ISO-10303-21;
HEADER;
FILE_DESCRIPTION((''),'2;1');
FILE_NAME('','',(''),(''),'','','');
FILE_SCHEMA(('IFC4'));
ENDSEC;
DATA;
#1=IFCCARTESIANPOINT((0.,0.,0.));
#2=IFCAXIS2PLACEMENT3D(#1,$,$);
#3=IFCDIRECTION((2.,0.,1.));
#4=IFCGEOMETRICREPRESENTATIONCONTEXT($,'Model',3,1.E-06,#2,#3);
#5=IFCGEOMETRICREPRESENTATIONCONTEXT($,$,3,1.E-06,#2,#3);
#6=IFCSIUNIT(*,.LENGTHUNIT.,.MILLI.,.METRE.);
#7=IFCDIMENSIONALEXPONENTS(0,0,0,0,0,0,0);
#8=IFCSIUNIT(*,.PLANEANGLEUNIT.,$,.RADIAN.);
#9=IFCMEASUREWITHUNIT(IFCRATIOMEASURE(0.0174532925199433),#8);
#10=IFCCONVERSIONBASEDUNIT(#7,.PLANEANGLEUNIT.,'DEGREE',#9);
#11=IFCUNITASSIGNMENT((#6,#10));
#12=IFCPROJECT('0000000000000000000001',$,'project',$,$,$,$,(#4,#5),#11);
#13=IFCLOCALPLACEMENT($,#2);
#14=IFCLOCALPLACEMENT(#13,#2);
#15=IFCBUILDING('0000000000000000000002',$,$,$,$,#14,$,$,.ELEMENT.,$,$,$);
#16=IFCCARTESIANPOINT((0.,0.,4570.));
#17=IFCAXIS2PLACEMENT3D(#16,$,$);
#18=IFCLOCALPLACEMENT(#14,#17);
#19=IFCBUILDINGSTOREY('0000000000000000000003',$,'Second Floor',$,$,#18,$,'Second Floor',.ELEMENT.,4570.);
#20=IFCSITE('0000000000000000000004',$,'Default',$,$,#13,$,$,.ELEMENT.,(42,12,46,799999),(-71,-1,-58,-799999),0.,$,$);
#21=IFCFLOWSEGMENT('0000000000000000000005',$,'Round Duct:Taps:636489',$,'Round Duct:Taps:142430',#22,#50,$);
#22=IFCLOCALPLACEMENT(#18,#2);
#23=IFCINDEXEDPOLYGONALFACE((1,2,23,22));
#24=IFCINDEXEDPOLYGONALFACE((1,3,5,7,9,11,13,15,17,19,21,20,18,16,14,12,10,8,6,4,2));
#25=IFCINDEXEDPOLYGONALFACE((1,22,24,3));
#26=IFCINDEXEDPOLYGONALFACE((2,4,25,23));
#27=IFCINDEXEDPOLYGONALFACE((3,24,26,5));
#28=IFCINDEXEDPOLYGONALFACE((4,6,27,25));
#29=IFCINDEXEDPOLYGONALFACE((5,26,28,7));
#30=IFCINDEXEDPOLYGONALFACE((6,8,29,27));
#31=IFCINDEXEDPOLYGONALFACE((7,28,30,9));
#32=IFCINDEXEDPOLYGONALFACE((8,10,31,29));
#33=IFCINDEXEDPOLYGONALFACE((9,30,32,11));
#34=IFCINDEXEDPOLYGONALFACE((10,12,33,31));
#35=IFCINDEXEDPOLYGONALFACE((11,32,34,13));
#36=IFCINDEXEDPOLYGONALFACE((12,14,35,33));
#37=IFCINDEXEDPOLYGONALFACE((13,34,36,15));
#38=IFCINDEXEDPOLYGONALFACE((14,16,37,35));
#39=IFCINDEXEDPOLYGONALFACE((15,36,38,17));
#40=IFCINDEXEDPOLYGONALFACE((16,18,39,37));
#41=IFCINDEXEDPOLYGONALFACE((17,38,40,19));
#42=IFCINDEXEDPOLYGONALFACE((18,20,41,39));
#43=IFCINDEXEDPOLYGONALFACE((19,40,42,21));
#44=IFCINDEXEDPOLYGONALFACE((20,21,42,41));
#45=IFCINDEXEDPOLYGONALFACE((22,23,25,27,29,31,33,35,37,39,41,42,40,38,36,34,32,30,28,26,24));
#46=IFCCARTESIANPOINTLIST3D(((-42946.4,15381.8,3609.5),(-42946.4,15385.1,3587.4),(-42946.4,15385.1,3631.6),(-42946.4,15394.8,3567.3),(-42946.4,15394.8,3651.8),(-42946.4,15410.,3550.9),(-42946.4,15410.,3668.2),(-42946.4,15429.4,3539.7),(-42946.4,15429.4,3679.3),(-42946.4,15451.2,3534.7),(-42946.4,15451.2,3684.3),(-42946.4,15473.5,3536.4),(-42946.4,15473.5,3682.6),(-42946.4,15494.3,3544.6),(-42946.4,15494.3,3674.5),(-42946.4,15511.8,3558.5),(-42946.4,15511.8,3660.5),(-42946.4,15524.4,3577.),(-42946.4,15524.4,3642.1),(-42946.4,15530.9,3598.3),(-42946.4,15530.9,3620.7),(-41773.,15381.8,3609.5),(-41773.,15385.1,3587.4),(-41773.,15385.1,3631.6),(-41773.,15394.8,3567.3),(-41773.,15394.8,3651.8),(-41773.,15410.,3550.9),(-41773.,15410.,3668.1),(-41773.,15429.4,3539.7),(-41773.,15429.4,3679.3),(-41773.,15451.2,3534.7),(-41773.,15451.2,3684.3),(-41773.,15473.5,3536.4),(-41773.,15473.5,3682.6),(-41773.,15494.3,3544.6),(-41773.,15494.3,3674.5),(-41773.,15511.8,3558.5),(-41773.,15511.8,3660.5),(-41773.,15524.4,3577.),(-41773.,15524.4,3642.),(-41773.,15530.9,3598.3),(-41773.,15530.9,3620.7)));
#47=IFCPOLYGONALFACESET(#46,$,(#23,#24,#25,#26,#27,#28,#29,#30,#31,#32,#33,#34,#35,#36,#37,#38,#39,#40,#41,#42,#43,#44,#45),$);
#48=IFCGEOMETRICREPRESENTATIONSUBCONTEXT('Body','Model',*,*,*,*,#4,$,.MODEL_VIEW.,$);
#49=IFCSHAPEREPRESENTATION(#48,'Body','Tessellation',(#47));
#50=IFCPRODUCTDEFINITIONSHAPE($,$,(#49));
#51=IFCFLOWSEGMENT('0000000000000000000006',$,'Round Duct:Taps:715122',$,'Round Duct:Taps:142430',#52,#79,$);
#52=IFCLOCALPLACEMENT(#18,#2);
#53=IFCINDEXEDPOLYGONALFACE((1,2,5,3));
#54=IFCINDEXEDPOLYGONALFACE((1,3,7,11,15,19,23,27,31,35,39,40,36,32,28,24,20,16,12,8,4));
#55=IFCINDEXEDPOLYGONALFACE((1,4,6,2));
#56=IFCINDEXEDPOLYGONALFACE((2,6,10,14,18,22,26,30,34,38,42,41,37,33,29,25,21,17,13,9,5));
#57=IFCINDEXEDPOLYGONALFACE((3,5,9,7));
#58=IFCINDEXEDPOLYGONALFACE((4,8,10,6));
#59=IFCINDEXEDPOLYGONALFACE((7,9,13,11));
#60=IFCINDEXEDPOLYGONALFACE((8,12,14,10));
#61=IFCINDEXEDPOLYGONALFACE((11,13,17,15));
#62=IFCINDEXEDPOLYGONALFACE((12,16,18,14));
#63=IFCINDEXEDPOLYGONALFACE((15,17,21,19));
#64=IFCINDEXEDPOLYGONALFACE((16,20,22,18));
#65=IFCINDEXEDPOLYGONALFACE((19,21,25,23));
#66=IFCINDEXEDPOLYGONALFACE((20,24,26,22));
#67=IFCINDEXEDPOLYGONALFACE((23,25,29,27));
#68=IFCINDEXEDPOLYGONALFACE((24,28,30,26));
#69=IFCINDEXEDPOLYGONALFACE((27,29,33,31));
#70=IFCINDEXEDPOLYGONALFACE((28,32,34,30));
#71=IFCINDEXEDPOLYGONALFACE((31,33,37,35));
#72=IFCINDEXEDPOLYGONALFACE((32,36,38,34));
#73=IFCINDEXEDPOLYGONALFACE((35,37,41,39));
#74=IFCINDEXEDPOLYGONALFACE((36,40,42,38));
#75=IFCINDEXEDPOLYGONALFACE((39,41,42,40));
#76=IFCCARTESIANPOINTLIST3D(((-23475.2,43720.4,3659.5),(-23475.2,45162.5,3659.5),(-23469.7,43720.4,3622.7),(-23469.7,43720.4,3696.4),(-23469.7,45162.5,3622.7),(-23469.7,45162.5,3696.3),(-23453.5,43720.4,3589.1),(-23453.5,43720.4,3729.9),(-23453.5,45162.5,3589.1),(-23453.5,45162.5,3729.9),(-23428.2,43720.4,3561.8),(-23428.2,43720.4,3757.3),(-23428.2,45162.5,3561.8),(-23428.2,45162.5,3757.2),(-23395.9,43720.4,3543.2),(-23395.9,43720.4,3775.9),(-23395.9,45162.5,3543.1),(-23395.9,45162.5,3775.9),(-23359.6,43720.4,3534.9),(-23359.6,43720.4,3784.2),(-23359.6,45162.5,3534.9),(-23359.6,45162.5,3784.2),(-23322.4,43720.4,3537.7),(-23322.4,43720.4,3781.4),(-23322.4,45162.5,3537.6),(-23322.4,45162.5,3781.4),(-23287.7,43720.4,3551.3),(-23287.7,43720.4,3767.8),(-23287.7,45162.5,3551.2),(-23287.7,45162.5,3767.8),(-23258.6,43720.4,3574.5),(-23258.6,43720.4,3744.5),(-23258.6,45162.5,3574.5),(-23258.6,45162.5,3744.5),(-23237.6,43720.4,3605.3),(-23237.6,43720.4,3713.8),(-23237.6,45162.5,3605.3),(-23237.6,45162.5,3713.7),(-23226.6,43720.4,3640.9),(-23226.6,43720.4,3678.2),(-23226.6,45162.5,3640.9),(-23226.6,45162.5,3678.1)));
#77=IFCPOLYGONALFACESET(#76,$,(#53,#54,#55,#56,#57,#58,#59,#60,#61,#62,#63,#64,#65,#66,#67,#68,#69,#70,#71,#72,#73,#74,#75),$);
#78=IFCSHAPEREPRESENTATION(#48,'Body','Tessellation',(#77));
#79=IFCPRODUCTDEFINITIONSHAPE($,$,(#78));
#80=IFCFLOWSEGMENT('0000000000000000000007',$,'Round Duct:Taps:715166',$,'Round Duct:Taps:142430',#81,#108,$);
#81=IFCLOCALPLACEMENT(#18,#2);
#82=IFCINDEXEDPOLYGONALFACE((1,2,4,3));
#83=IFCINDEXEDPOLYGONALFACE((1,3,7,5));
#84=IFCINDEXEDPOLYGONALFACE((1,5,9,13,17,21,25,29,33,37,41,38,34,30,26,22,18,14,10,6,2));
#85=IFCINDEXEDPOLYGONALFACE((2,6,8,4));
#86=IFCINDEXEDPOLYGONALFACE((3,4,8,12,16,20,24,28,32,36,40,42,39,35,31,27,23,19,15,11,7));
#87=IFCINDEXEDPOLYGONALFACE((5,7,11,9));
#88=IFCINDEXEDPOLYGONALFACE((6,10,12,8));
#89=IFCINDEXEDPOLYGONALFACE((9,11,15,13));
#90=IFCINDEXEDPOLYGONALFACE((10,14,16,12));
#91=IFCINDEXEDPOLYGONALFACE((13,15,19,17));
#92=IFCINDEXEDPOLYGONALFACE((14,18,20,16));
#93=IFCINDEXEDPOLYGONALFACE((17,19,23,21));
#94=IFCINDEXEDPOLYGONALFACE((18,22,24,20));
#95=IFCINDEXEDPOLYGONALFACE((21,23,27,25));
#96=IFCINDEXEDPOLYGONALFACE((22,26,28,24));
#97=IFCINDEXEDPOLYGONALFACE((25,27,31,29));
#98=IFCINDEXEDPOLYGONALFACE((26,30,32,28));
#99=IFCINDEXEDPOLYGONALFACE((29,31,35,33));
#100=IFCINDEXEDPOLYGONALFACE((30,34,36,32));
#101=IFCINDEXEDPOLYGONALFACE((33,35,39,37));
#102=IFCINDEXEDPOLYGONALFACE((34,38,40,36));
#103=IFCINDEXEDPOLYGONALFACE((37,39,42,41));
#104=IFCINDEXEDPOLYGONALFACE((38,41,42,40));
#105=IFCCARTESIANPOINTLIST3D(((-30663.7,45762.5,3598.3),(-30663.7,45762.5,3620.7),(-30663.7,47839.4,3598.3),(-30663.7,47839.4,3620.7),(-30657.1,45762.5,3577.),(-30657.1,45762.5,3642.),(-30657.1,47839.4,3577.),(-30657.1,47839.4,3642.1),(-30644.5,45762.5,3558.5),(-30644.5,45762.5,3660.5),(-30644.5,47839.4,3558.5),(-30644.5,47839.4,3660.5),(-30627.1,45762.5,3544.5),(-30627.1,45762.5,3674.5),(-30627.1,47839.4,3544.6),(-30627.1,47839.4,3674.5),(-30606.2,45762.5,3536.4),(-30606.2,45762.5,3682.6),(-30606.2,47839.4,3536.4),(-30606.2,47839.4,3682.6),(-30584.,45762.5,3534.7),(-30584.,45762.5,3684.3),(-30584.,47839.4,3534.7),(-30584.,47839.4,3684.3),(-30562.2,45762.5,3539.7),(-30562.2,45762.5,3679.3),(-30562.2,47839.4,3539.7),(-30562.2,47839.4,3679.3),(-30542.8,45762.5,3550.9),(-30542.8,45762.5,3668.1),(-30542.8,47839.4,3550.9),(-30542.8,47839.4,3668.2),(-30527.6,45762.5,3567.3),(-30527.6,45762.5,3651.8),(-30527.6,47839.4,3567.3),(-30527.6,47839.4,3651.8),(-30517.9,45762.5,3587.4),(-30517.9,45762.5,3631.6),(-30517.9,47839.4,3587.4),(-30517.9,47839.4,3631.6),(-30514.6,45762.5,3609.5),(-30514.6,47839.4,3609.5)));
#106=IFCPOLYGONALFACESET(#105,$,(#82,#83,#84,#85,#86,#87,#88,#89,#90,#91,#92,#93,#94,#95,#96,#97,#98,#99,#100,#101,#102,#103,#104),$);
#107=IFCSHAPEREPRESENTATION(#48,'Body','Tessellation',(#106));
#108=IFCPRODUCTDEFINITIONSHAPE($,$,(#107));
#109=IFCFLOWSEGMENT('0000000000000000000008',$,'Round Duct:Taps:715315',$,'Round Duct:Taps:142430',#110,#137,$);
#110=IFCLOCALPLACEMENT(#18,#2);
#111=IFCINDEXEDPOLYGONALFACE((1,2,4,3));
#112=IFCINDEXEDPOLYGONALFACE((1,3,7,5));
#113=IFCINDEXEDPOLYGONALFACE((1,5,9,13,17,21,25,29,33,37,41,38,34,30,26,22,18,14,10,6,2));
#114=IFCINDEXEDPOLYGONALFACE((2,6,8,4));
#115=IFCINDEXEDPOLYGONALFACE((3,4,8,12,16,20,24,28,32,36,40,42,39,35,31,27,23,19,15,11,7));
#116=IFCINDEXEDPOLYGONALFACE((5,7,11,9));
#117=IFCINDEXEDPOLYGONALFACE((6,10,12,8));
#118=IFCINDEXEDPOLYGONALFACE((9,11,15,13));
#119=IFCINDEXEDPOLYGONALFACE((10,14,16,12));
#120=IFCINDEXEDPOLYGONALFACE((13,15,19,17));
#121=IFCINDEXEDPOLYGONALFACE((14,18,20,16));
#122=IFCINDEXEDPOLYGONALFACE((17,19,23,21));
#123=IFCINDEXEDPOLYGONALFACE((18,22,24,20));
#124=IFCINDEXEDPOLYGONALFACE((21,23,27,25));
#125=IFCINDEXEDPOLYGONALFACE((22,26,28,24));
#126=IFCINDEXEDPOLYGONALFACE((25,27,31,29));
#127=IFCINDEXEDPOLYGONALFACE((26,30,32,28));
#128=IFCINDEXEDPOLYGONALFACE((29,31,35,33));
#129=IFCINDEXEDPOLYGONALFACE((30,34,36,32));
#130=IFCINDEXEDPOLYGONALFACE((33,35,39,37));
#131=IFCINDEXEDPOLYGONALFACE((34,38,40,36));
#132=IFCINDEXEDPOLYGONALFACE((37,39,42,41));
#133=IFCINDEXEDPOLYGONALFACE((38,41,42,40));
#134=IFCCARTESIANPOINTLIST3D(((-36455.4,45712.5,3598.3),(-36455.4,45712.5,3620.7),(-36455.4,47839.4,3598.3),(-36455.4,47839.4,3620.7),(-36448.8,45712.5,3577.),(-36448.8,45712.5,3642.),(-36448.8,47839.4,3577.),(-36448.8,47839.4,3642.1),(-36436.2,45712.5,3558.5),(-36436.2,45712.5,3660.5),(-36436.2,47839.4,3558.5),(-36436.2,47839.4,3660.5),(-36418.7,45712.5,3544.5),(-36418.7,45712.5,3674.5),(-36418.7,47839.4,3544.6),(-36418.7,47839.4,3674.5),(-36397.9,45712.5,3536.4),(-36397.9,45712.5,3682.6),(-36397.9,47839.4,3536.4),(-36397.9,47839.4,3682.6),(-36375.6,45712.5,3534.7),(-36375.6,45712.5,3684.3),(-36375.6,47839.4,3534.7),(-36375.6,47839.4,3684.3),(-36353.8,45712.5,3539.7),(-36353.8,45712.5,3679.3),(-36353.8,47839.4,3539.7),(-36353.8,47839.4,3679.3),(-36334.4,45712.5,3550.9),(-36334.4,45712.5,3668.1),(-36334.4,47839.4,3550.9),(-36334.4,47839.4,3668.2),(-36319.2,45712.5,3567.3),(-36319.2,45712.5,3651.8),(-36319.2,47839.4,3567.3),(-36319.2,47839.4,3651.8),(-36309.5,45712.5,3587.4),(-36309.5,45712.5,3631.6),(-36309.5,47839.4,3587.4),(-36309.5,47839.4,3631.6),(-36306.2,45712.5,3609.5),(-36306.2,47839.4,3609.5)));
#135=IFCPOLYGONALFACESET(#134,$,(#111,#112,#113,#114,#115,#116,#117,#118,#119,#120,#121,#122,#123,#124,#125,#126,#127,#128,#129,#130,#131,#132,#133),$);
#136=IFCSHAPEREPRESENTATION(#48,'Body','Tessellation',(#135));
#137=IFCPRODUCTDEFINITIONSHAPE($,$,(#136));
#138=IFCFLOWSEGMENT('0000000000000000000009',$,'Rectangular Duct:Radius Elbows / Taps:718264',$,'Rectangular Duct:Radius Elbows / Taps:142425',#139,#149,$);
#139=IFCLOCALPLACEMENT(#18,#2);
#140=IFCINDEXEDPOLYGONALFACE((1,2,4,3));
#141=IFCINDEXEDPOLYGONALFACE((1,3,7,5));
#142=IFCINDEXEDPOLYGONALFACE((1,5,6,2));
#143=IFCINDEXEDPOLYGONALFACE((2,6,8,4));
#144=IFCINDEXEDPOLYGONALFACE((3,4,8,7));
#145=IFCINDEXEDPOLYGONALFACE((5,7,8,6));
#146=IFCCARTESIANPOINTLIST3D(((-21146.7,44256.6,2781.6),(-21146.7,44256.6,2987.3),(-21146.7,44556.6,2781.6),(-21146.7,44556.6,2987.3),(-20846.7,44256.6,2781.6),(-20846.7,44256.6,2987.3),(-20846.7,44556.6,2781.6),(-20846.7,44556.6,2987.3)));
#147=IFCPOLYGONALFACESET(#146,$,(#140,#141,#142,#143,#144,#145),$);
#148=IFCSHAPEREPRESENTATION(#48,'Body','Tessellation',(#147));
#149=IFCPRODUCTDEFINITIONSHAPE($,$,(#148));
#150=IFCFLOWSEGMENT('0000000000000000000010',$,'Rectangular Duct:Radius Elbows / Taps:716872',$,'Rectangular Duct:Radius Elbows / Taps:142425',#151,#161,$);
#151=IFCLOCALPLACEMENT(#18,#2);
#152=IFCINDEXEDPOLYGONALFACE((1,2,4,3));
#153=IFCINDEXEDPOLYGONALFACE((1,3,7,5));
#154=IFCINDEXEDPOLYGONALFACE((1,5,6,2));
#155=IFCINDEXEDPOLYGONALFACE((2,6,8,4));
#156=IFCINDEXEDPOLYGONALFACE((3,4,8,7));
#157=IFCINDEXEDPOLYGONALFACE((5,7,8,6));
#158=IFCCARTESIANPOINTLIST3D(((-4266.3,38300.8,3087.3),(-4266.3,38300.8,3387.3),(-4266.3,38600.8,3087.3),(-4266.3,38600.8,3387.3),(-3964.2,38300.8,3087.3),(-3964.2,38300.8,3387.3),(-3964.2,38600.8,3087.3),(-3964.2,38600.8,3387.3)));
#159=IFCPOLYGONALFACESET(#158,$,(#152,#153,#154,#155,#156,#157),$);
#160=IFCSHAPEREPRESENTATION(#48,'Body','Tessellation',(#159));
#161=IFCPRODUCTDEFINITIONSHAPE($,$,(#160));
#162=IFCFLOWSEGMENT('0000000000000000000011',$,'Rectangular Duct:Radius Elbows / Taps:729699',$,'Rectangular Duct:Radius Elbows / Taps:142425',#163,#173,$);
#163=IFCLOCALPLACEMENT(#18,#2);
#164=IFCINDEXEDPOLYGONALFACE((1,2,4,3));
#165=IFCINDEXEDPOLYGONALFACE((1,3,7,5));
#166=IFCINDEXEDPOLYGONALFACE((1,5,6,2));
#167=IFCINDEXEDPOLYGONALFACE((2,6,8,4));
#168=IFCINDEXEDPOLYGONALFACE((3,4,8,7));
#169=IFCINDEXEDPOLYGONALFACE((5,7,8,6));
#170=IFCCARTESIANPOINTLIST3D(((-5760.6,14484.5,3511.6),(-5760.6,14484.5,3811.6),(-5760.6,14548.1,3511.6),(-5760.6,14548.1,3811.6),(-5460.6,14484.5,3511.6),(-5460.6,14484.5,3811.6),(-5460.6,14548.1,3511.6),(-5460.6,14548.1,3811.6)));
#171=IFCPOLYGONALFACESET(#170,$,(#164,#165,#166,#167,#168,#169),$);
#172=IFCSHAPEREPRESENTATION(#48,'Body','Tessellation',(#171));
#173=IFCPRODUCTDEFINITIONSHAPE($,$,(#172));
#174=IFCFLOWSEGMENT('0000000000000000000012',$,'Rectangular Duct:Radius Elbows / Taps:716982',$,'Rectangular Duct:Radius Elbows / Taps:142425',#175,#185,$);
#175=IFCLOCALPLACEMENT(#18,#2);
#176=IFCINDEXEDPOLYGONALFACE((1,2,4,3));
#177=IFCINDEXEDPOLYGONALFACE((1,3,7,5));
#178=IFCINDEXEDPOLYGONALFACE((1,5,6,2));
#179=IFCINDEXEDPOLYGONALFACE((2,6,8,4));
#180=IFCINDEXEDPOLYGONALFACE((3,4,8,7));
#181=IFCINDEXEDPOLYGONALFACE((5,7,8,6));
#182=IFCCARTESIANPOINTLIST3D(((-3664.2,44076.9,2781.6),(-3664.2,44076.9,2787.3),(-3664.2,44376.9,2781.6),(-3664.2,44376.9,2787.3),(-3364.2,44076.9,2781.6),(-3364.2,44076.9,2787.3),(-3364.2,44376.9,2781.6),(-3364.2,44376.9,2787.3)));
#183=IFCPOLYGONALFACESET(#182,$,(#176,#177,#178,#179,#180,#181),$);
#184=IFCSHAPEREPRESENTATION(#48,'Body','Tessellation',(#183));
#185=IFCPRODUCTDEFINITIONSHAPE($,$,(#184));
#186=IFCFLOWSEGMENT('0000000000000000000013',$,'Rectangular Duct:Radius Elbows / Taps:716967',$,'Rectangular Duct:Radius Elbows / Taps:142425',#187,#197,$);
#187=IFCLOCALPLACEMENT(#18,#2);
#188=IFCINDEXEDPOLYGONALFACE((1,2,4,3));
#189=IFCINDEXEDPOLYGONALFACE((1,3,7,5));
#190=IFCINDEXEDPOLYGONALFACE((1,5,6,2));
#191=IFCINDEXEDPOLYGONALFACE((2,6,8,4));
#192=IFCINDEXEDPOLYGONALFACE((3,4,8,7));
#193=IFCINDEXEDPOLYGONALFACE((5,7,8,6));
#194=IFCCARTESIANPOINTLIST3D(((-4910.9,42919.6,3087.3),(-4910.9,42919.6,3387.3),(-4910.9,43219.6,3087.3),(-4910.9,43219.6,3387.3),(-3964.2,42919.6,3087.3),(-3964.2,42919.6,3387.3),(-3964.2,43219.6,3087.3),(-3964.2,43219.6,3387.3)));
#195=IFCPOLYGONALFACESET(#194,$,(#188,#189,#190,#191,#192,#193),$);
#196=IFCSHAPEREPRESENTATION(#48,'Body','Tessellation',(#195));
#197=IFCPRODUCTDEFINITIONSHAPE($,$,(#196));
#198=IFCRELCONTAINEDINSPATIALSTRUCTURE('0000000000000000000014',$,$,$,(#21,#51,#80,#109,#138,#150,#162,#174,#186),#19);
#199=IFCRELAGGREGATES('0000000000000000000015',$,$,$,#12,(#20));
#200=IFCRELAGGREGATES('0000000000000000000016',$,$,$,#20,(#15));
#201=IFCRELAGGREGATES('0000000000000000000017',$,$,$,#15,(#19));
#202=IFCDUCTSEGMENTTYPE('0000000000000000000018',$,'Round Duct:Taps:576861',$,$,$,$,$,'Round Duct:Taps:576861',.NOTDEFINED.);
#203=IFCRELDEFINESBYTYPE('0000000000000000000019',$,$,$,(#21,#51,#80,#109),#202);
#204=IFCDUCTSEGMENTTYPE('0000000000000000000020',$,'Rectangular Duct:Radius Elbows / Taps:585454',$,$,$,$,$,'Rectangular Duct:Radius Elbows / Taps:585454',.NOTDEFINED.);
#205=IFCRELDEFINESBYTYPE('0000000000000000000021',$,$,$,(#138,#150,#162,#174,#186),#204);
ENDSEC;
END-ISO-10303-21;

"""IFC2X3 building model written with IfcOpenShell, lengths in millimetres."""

from ifc_helpers import new_model, entity, si_unit, converted_unit, direction, frame, frame_2d, origin, origin_2d_with_axis, place, context, subcontext, project, spatial, rectangle, circle, extrude, type_object, element, save


model = new_model("IFC2X3")

# Units and contexts
model_context = context("Model", 3, precision=1e-06, world=origin(), true_north=direction((2.0, 0.0, 1.0)))
context_of_model = context(None, 3, precision=1e-06, world=origin(), true_north=direction((2.0, 0.0, 1.0)))
body_context = subcontext(model_context, "Body", "Model", "MODEL_VIEW")
ifc_project = project(units=[si_unit("LENGTHUNIT", "METRE", prefix="MILLI"), converted_unit("PLANEANGLEUNIT", "DEGREE", entity("IfcRatioMeasure", 0.0174532925199433), si_unit("PLANEANGLEUNIT", "RADIAN"), dimensions=[0, 0, 0, 0, 0, 0, 0])], contexts=[model_context, context_of_model])

# Site, building, storey
site_placement = place(None, origin())
site = spatial("IfcSite", under=ifc_project, at=site_placement, Name="Default", CompositionType="ELEMENT", RefLatitude=(42, 12, 46, 799999), RefLongitude=(-71, -1, -58, -799999), RefElevation=0.0)
building_placement = place(site_placement, origin())
building = spatial("IfcBuilding", under=site, at=building_placement, CompositionType="ELEMENT")
storey_placement = place(building_placement, frame((0.0, 0.0, 4570.0)))
storey = spatial("IfcBuildingStorey", under=building, at=storey_placement, Name="Second Floor", LongName="Second Floor", CompositionType="ELEMENT", Elevation=4570.0)

# Flow segments
duct_segment_type_1 = type_object("IfcDuctSegmentType", Name="Round Duct:Taps:576861", ElementType="Round Duct:Taps:576861", PredefinedType="NOTDEFINED")
flow_segment_1_placement = place(storey_placement, origin())
element("IfcFlowSegment", 1, at=flow_segment_1_placement, inside=storey, type_object=duct_segment_type_1, Name="Round Duct:Taps:636489", ObjectType="Round Duct:Taps:142430", context=body_context, shape_type="SweptSolid", body=[
    extrude(circle(Radius=75.0, at=origin_2d_with_axis()), frame((-42946.4, 15456.8, 3609.5), z_axis=(1.0, 0.0, -0.000018), x_axis=(0.0, -1.0, 0.0)), (0.0, 0.0, 1.0), 1173.4),
])
flow_segment_2_placement = place(storey_placement, origin())
element("IfcFlowSegment", 2, at=flow_segment_2_placement, inside=storey, type_object=duct_segment_type_1, Name="Round Duct:Taps:715122", ObjectType="Round Duct:Taps:142430", context=body_context, shape_type="SweptSolid", body=[
    extrude(circle(Radius=125.0, at=frame_2d((0.0, 0.0), x_axis=(1.0, 0.0))), frame((-23350.2, 43720.4, 3659.5), z_axis=(0.0, 1.0, -0.000016), x_axis=(-1.0, 0.0, 0.0)), (0.0, 0.0, 1.0), 1442.0),
])
flow_segment_3_placement = place(storey_placement, origin())
element("IfcFlowSegment", 3, at=flow_segment_3_placement, inside=storey, type_object=duct_segment_type_1, Name="Round Duct:Taps:715166", ObjectType="Round Duct:Taps:142430", context=body_context, shape_type="SweptSolid", body=[
    extrude(circle(Radius=75.0, at=origin_2d_with_axis()), frame((-30589.6, 45762.5, 3609.5), z_axis=(0.0, 1.0, 0.000011), x_axis=(1.0, 0.0, 0.0)), (0.0, 0.0, 1.0), 2077.0),
])
flow_segment_4_placement = place(storey_placement, origin())
element("IfcFlowSegment", 4, at=flow_segment_4_placement, inside=storey, type_object=duct_segment_type_1, Name="Round Duct:Taps:715315", ObjectType="Round Duct:Taps:142430", context=body_context, shape_type="SweptSolid", body=[
    extrude(circle(Radius=75.0, at=frame_2d((0.0, 0.0), x_axis=(1.0, 0.0))), frame((-36381.2, 45712.5, 3609.5), z_axis=(0.0, 1.0, 0.000011), x_axis=(1.0, 0.0, 0.0)), (0.0, 0.0, 1.0), 2127.0),
])
duct_segment_type_2 = type_object("IfcDuctSegmentType", Name="Rectangular Duct:Radius Elbows / Taps:585454", ElementType="Rectangular Duct:Radius Elbows / Taps:585454", PredefinedType="NOTDEFINED")
flow_segment_5_placement = place(storey_placement, origin())
element("IfcFlowSegment", 5, at=flow_segment_5_placement, inside=storey, type_object=duct_segment_type_2, Name="Rectangular Duct:Radius Elbows / Taps:718264", ObjectType="Rectangular Duct:Radius Elbows / Taps:142425", context=body_context, shape_type="SweptSolid", body=[
    extrude(rectangle(XDim=300.0, YDim=300.0, at=origin_2d_with_axis()), frame((-20996.7, 44406.6, 2781.6), z_axis=(0.0, 0.0, 1.0), x_axis=(-1.0, 0.0, 0.0)), (0.0, 0.0, 1.0), 205.7),
])
flow_segment_6_placement = place(storey_placement, origin())
element("IfcFlowSegment", 6, at=flow_segment_6_placement, inside=storey, type_object=duct_segment_type_2, Name="Rectangular Duct:Radius Elbows / Taps:716872", ObjectType="Rectangular Duct:Radius Elbows / Taps:142425", context=body_context, shape_type="SweptSolid", body=[
    extrude(rectangle(XDim=302.2, YDim=300.0, at=origin_2d_with_axis()), frame((-4115.3, 38450.8, 3087.3), z_axis=(0.0, 0.0, 1.0), x_axis=(-1.0, 0.0, 0.0)), (0.0, 0.0, 1.0), 300.0),
])
flow_segment_7_placement = place(storey_placement, origin())
element("IfcFlowSegment", 7, at=flow_segment_7_placement, inside=storey, type_object=duct_segment_type_2, Name="Rectangular Duct:Radius Elbows / Taps:729699", ObjectType="Rectangular Duct:Radius Elbows / Taps:142425", context=body_context, shape_type="SweptSolid", body=[
    extrude(rectangle(XDim=63.6, YDim=300.0, at=origin_2d_with_axis()), frame((-5610.6, 14516.3, 3511.6), z_axis=(0.0, 0.0, 1.0), x_axis=(0.0, 1.0, 0.0)), (0.0, 0.0, 1.0), 300.0),
])
flow_segment_8_placement = place(storey_placement, origin())
element("IfcFlowSegment", 8, at=flow_segment_8_placement, inside=storey, type_object=duct_segment_type_2, Name="Rectangular Duct:Radius Elbows / Taps:716982", ObjectType="Rectangular Duct:Radius Elbows / Taps:142425", context=body_context, shape_type="SweptSolid", body=[
    extrude(rectangle(XDim=300.0, YDim=300.0, at=origin_2d_with_axis()), frame((-3514.2, 44226.9, 2781.6), z_axis=(0.0, 0.0, 1.0), x_axis=(0.0, 1.0, 0.0)), (0.0, 0.0, 1.0), 5.7),
])
flow_segment_9_placement = place(storey_placement, origin())
element("IfcFlowSegment", 9, at=flow_segment_9_placement, inside=storey, type_object=duct_segment_type_2, Name="Rectangular Duct:Radius Elbows / Taps:716967", ObjectType="Rectangular Duct:Radius Elbows / Taps:142425", context=body_context, shape_type="SweptSolid", body=[
    extrude(rectangle(XDim=946.7, YDim=300.0, at=frame_2d((0.0, 0.0), x_axis=(1.0, 0.0))), frame((-4437.5, 43069.6, 3087.3)), (0.0, 0.0, 1.0), 300.0),
])

save(model, "model.ifc")
